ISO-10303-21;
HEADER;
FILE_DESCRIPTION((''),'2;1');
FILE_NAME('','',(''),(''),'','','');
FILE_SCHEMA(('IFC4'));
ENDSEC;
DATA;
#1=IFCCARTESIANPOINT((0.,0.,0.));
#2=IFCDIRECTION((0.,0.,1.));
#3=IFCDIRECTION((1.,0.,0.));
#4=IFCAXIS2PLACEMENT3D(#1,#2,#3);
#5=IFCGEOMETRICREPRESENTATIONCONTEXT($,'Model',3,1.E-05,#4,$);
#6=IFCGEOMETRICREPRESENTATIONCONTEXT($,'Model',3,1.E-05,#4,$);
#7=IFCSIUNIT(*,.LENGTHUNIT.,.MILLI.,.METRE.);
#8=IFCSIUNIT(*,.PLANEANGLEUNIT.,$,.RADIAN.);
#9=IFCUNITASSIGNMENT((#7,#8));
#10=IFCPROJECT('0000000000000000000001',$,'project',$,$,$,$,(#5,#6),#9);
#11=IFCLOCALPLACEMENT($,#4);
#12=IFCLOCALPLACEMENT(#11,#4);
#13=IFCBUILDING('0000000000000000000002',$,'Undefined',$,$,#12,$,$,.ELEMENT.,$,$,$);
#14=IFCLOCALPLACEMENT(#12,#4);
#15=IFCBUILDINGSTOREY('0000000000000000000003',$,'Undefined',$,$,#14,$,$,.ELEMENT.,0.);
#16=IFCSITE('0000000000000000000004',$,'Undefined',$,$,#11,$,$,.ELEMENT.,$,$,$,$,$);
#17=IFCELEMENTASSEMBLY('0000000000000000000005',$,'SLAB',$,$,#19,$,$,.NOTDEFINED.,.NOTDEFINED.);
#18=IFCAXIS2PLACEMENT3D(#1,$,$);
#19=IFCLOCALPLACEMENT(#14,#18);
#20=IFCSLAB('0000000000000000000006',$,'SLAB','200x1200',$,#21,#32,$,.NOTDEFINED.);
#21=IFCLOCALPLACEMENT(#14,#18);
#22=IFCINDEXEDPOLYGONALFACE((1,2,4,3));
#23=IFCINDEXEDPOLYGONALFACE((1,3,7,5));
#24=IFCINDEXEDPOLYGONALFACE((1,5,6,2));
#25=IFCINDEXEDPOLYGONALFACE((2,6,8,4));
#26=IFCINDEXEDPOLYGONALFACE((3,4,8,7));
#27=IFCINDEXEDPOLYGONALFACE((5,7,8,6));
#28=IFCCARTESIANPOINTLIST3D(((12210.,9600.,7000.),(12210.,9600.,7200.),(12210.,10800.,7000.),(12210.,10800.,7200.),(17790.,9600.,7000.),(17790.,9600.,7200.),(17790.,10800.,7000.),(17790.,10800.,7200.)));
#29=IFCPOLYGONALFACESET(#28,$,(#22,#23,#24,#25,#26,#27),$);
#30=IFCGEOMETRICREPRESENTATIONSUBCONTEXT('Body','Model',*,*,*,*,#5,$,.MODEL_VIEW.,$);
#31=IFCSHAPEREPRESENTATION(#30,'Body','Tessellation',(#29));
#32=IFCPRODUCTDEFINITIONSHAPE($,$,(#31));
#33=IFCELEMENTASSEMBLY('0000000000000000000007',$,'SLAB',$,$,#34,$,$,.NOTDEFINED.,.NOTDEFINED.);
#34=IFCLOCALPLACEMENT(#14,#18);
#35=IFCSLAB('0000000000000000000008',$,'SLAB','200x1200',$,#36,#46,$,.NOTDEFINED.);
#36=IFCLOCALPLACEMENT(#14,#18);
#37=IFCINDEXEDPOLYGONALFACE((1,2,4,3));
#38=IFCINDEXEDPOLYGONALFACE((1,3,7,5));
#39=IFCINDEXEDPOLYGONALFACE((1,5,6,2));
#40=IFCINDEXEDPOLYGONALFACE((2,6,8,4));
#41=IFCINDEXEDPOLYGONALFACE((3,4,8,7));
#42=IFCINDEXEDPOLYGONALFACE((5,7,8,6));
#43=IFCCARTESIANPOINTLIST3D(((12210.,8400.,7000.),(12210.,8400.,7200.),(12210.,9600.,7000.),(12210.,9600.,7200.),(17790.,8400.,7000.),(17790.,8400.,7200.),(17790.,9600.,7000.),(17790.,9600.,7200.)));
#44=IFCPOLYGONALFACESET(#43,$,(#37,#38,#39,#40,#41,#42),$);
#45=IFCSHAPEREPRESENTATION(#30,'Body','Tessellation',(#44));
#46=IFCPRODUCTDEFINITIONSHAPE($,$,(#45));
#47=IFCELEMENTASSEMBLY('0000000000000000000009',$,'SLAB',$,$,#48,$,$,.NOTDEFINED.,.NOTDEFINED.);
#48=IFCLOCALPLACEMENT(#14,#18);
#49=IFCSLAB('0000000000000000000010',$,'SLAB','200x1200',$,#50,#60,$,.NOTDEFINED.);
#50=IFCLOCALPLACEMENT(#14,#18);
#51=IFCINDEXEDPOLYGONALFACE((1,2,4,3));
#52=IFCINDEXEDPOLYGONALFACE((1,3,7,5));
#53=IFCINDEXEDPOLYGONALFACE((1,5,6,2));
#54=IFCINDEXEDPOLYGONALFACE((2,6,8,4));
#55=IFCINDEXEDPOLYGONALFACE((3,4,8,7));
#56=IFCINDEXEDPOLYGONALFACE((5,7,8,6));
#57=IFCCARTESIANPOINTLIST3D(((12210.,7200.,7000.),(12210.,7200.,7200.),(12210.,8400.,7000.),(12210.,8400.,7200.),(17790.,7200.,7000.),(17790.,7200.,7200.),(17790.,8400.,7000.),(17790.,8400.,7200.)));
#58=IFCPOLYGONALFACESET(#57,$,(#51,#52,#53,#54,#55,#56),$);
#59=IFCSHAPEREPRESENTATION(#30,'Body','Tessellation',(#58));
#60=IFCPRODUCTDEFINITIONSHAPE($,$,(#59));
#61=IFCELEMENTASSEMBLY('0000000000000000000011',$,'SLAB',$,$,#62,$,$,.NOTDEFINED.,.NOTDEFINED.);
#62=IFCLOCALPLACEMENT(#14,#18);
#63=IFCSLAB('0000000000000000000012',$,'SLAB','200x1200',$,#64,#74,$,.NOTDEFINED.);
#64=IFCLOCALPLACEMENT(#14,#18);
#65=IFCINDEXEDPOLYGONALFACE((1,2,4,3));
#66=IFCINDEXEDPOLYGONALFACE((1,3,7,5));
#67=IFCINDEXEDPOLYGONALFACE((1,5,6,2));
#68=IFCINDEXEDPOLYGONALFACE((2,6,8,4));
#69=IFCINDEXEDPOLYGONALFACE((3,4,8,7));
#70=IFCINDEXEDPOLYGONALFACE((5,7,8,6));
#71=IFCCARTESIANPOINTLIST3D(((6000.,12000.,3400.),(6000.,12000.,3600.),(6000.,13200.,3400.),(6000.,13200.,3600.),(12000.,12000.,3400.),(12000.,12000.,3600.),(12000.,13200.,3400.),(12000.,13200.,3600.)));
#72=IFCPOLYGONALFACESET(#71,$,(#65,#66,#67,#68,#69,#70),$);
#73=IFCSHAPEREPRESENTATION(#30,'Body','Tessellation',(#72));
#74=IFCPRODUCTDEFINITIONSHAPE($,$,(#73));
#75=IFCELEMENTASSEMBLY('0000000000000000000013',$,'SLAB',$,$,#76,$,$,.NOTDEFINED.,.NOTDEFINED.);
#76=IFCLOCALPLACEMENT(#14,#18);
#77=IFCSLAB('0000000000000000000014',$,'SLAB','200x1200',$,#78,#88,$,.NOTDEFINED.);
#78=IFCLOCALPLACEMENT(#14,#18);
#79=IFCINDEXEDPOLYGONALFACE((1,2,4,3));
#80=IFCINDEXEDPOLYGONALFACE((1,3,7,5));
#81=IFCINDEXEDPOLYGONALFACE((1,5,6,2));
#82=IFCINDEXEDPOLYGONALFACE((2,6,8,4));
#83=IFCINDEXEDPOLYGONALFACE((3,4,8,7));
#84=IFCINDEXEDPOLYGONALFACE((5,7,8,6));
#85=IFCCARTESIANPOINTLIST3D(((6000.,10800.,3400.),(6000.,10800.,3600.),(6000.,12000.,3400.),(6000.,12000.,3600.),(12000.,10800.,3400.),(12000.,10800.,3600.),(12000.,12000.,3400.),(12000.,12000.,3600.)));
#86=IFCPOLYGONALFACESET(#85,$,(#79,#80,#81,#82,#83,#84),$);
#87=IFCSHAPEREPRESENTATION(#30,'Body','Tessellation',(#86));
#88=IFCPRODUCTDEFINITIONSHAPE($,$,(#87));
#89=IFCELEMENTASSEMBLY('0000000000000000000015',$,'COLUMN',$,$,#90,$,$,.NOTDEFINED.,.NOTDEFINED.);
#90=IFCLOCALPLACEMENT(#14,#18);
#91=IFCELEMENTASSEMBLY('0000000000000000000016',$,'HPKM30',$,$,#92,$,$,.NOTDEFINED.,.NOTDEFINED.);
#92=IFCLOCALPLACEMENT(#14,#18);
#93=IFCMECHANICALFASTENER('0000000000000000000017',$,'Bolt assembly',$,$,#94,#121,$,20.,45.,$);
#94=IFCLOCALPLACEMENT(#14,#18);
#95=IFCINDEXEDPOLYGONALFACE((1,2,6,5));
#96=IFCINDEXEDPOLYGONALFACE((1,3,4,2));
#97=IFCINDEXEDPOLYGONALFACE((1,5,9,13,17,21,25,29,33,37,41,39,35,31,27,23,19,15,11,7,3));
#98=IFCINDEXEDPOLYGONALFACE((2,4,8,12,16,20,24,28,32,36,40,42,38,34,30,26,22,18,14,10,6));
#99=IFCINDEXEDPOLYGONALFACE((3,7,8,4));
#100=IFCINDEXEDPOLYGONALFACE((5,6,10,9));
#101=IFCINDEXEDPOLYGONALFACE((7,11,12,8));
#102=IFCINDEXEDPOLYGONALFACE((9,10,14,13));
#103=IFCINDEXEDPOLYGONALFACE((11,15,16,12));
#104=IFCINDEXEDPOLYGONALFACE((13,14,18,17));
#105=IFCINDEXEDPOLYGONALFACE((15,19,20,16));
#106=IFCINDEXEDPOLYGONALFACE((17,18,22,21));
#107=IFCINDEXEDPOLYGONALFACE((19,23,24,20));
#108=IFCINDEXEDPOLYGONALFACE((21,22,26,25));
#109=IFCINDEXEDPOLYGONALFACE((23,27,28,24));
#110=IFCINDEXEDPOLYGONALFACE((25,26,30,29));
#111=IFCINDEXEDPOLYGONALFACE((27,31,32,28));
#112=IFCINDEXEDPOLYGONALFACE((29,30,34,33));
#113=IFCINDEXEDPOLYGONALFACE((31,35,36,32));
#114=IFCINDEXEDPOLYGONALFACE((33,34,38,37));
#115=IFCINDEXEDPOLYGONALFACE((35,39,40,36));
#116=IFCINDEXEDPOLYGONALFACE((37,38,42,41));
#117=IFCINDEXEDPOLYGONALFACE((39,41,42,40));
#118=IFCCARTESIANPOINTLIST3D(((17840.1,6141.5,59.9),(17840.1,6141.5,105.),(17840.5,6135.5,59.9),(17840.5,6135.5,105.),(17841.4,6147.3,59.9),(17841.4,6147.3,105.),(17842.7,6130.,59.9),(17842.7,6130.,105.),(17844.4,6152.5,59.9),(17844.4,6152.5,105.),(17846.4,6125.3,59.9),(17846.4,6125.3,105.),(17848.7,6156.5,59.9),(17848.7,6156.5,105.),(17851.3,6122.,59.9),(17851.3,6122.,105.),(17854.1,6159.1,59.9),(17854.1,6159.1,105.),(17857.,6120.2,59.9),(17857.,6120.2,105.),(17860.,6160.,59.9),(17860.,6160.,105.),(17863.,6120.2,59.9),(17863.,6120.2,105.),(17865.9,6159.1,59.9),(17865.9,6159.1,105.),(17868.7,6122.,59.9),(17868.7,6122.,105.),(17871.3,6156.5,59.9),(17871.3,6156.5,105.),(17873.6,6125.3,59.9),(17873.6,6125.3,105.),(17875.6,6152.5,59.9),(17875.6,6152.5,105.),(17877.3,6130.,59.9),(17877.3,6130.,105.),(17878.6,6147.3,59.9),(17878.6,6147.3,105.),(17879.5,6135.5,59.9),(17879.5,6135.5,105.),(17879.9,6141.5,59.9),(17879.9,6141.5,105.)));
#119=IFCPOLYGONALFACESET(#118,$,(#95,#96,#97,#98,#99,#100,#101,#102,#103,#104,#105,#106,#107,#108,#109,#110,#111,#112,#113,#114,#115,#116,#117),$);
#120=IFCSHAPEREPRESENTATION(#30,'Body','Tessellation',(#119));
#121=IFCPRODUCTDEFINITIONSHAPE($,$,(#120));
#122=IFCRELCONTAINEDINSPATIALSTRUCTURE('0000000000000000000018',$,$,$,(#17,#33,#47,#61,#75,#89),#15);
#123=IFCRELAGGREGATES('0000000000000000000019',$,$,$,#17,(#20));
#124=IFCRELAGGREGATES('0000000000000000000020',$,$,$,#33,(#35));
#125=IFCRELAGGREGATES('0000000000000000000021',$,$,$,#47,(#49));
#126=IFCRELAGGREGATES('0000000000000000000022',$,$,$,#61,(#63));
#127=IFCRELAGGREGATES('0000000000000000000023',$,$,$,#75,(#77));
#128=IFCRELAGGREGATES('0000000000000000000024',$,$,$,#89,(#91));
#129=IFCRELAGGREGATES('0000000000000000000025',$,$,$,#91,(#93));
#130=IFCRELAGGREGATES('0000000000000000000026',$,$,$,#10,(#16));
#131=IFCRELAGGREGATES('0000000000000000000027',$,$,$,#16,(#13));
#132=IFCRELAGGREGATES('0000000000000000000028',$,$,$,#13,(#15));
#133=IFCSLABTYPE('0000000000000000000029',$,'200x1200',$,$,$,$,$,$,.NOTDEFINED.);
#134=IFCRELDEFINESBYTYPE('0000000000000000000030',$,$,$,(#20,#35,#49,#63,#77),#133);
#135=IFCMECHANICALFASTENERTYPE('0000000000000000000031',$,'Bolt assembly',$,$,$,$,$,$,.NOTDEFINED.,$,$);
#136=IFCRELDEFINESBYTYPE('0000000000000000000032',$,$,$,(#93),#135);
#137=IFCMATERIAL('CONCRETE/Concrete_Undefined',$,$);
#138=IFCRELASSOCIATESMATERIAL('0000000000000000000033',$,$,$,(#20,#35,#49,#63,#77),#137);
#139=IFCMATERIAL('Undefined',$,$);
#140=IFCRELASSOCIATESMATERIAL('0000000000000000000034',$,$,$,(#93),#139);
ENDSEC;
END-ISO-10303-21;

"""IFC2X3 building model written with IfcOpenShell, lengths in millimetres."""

from ifc_helpers import new_model, si_unit, frame, origin_with_axes, origin_2d_with_axis, place, context, subcontext, project, spatial, polyline, circle, outline, extrude, source, transform, mapped, material, type_object, element, aggregate, save


model = new_model("IFC2X3")

# Units and contexts
model_context_1 = context("Model", 3, precision=1e-05, world=origin_with_axes())
model_context_2 = context("Model", 3, precision=1e-05, world=origin_with_axes())
body_context = subcontext(model_context_1, "Body", "Model", "MODEL_VIEW")
ifc_project = project(units=[si_unit("LENGTHUNIT", "METRE", prefix="MILLI"), si_unit("PLANEANGLEUNIT", "RADIAN")], contexts=[model_context_1, model_context_2])

# Site, building, storey
site_placement = place(None, origin_with_axes())
site = spatial("IfcSite", under=ifc_project, at=site_placement, Name="Undefined", CompositionType="ELEMENT")
building_placement = place(site_placement, origin_with_axes())
building = spatial("IfcBuilding", under=site, at=building_placement, Name="Undefined", CompositionType="ELEMENT")
storey_placement = place(building_placement, origin_with_axes())
storey = spatial("IfcBuildingStorey", under=building, at=storey_placement, Name="Undefined", CompositionType="ELEMENT", Elevation=0.0)

# Shared definitions
ifc_material_1 = material(Name="CONCRETE/Concrete_Undefined")

# Element assemblies, slabs
slab_type = type_object("IfcSlabType", Name="200x1200", PredefinedType="NOTDEFINED")
assembly_1_placement = place(storey_placement, origin_with_axes())
assembly_1 = element("IfcElementAssembly", 1, at=assembly_1_placement, inside=storey, Name="SLAB", AssemblyPlace="NOTDEFINED", PredefinedType="NOTDEFINED")
slab_1_placement = place(assembly_1_placement, frame((17790.0, 9600.0, 7100.0), z_axis=(0.0, 0.0, 1.0), x_axis=(0.0, 1.0, 0.0)))
slab_1 = element("IfcSlab", 2, at=slab_1_placement, type_object=slab_type, material=ifc_material_1, Name="SLAB", Description="200x1200", PredefinedType="NOTDEFINED", context=body_context, shape_type="SweptSolid", body=[
    extrude(outline(polyline([(0.0, 0.0), (1200.0, 0.0), (1200.0, 5580.0), (0.0, 5580.0), (0.0, 0.0)])), frame((0.0, 0.0, -100.0), z_axis=(0.0, 0.0, 1.0), x_axis=(1.0, 0.0, 0.0)), (0.0, 0.0, 1.0), 200.0),
])
aggregate(assembly_1, [slab_1])
assembly_2_placement = place(storey_placement, origin_with_axes())
assembly_2 = element("IfcElementAssembly", 3, at=assembly_2_placement, inside=storey, Name="SLAB", AssemblyPlace="NOTDEFINED", PredefinedType="NOTDEFINED")
slab_2_placement = place(assembly_2_placement, frame((17790.0, 8400.0, 7100.0), z_axis=(0.0, 0.0, 1.0), x_axis=(0.0, 1.0, 0.0)))
slab_2 = element("IfcSlab", 4, at=slab_2_placement, type_object=slab_type, material=ifc_material_1, Name="SLAB", Description="200x1200", PredefinedType="NOTDEFINED", context=body_context, shape_type="SweptSolid", body=[
    extrude(outline(polyline([(0.0, 0.0), (1200.0, 0.0), (1200.0, 5580.0), (0.0, 5580.0), (0.0, 0.0)])), frame((0.0, 0.0, -100.0), z_axis=(0.0, 0.0, 1.0), x_axis=(1.0, 0.0, 0.0)), (0.0, 0.0, 1.0), 200.0),
])
aggregate(assembly_2, [slab_2])
assembly_3_placement = place(storey_placement, origin_with_axes())
assembly_3 = element("IfcElementAssembly", 5, at=assembly_3_placement, inside=storey, Name="SLAB", AssemblyPlace="NOTDEFINED", PredefinedType="NOTDEFINED")
slab_3_placement = place(assembly_3_placement, frame((17790.0, 7200.0, 7100.0), z_axis=(0.0, 0.0, 1.0), x_axis=(0.0, 1.0, 0.0)))
slab_3 = element("IfcSlab", 6, at=slab_3_placement, type_object=slab_type, material=ifc_material_1, Name="SLAB", Description="200x1200", PredefinedType="NOTDEFINED", context=body_context, shape_type="SweptSolid", body=[
    extrude(outline(polyline([(0.0, 0.0), (1200.0, 0.0), (1200.0, 5580.0), (0.0, 5580.0), (0.0, 0.0)])), frame((0.0, 0.0, -100.0), z_axis=(0.0, 0.0, 1.0), x_axis=(1.0, 0.0, 0.0)), (0.0, 0.0, 1.0), 200.0),
])
aggregate(assembly_3, [slab_3])
assembly_4_placement = place(storey_placement, origin_with_axes())
assembly_4 = element("IfcElementAssembly", 7, at=assembly_4_placement, inside=storey, Name="SLAB", AssemblyPlace="NOTDEFINED", PredefinedType="NOTDEFINED")
slab_4_placement = place(assembly_4_placement, frame((12000.0, 12000.0, 3500.0), z_axis=(0.0, 0.0, 1.0), x_axis=(0.0, 1.0, 0.0)))
slab_4 = element("IfcSlab", 8, at=slab_4_placement, type_object=slab_type, material=ifc_material_1, Name="SLAB", Description="200x1200", PredefinedType="NOTDEFINED", context=body_context, shape_type="SweptSolid", body=[
    extrude(outline(polyline([(0.0, 0.0), (1200.0, 0.0), (1200.0, 6000.0), (0.0, 6000.0), (0.0, 0.0)])), frame((0.0, 0.0, -100.0), z_axis=(0.0, 0.0, 1.0), x_axis=(1.0, 0.0, 0.0)), (0.0, 0.0, 1.0), 200.0),
])
aggregate(assembly_4, [slab_4])
assembly_5_placement = place(storey_placement, origin_with_axes())
assembly_5 = element("IfcElementAssembly", 9, at=assembly_5_placement, inside=storey, Name="SLAB", AssemblyPlace="NOTDEFINED", PredefinedType="NOTDEFINED")
slab_5_placement = place(assembly_5_placement, frame((12000.0, 10800.0, 3500.0), z_axis=(0.0, 0.0, 1.0), x_axis=(0.0, 1.0, 0.0)))
slab_5 = element("IfcSlab", 10, at=slab_5_placement, type_object=slab_type, material=ifc_material_1, Name="SLAB", Description="200x1200", PredefinedType="NOTDEFINED", context=body_context, shape_type="SweptSolid", body=[
    extrude(outline(polyline([(0.0, 0.0), (1200.0, 0.0), (1200.0, 6000.0), (0.0, 6000.0), (0.0, 0.0)])), frame((0.0, 0.0, -100.0), z_axis=(0.0, 0.0, 1.0), x_axis=(1.0, 0.0, 0.0)), (0.0, 0.0, 1.0), 200.0),
])
aggregate(assembly_5, [slab_5])

# Shared definitions
mechanical_fastener_type = type_object("IfcMechanicalFastenerType", Name="Bolt assembly")

# Element assemblies, mechanical fastener
assembly_6_placement = place(storey_placement, origin_with_axes())
assembly_6 = element("IfcElementAssembly", 11, at=assembly_6_placement, inside=storey, Name="COLUMN", AssemblyPlace="NOTDEFINED", PredefinedType="NOTDEFINED")
assembly_7_placement = place(assembly_6_placement, origin_with_axes())
assembly_7 = element("IfcElementAssembly", 12, at=assembly_7_placement, Name="HPKM30", AssemblyPlace="NOTDEFINED", PredefinedType="NOTDEFINED")
aggregate(assembly_6, [assembly_7])
ifc_material_2 = material(Name="Undefined")
shared_shape_1 = source(origin_with_axes(), body_context, "Body", "SweptSolid", [
    extrude(circle(Radius=20.0, at=origin_2d_with_axis()), frame((0.0, -45.0, 0.0), z_axis=(0.0, 1.0, 0.0), x_axis=(1.0, 0.0, 0.0)), (0.0, 0.0, 1.0), 45.1),
])
mechanical_fastener_1_placement = place(assembly_7_placement, frame((17860.0, 6140.0, 60.0), z_axis=(-1.0, 0.0, 0.0), x_axis=(0.0, 1.0, 0.0)))
mechanical_fastener_1 = element("IfcMechanicalFastener", 13, at=mechanical_fastener_1_placement, type_object=mechanical_fastener_type, material=ifc_material_2, Name="Bolt assembly", NominalDiameter=20.0, NominalLength=45.0, context=body_context, shape_type="MappedRepresentation", body=[
    mapped(shared_shape_1, transform((0.0, 0.0, 0.0))),
])
aggregate(assembly_7, [mechanical_fastener_1])

save(model, "model.ifc")
